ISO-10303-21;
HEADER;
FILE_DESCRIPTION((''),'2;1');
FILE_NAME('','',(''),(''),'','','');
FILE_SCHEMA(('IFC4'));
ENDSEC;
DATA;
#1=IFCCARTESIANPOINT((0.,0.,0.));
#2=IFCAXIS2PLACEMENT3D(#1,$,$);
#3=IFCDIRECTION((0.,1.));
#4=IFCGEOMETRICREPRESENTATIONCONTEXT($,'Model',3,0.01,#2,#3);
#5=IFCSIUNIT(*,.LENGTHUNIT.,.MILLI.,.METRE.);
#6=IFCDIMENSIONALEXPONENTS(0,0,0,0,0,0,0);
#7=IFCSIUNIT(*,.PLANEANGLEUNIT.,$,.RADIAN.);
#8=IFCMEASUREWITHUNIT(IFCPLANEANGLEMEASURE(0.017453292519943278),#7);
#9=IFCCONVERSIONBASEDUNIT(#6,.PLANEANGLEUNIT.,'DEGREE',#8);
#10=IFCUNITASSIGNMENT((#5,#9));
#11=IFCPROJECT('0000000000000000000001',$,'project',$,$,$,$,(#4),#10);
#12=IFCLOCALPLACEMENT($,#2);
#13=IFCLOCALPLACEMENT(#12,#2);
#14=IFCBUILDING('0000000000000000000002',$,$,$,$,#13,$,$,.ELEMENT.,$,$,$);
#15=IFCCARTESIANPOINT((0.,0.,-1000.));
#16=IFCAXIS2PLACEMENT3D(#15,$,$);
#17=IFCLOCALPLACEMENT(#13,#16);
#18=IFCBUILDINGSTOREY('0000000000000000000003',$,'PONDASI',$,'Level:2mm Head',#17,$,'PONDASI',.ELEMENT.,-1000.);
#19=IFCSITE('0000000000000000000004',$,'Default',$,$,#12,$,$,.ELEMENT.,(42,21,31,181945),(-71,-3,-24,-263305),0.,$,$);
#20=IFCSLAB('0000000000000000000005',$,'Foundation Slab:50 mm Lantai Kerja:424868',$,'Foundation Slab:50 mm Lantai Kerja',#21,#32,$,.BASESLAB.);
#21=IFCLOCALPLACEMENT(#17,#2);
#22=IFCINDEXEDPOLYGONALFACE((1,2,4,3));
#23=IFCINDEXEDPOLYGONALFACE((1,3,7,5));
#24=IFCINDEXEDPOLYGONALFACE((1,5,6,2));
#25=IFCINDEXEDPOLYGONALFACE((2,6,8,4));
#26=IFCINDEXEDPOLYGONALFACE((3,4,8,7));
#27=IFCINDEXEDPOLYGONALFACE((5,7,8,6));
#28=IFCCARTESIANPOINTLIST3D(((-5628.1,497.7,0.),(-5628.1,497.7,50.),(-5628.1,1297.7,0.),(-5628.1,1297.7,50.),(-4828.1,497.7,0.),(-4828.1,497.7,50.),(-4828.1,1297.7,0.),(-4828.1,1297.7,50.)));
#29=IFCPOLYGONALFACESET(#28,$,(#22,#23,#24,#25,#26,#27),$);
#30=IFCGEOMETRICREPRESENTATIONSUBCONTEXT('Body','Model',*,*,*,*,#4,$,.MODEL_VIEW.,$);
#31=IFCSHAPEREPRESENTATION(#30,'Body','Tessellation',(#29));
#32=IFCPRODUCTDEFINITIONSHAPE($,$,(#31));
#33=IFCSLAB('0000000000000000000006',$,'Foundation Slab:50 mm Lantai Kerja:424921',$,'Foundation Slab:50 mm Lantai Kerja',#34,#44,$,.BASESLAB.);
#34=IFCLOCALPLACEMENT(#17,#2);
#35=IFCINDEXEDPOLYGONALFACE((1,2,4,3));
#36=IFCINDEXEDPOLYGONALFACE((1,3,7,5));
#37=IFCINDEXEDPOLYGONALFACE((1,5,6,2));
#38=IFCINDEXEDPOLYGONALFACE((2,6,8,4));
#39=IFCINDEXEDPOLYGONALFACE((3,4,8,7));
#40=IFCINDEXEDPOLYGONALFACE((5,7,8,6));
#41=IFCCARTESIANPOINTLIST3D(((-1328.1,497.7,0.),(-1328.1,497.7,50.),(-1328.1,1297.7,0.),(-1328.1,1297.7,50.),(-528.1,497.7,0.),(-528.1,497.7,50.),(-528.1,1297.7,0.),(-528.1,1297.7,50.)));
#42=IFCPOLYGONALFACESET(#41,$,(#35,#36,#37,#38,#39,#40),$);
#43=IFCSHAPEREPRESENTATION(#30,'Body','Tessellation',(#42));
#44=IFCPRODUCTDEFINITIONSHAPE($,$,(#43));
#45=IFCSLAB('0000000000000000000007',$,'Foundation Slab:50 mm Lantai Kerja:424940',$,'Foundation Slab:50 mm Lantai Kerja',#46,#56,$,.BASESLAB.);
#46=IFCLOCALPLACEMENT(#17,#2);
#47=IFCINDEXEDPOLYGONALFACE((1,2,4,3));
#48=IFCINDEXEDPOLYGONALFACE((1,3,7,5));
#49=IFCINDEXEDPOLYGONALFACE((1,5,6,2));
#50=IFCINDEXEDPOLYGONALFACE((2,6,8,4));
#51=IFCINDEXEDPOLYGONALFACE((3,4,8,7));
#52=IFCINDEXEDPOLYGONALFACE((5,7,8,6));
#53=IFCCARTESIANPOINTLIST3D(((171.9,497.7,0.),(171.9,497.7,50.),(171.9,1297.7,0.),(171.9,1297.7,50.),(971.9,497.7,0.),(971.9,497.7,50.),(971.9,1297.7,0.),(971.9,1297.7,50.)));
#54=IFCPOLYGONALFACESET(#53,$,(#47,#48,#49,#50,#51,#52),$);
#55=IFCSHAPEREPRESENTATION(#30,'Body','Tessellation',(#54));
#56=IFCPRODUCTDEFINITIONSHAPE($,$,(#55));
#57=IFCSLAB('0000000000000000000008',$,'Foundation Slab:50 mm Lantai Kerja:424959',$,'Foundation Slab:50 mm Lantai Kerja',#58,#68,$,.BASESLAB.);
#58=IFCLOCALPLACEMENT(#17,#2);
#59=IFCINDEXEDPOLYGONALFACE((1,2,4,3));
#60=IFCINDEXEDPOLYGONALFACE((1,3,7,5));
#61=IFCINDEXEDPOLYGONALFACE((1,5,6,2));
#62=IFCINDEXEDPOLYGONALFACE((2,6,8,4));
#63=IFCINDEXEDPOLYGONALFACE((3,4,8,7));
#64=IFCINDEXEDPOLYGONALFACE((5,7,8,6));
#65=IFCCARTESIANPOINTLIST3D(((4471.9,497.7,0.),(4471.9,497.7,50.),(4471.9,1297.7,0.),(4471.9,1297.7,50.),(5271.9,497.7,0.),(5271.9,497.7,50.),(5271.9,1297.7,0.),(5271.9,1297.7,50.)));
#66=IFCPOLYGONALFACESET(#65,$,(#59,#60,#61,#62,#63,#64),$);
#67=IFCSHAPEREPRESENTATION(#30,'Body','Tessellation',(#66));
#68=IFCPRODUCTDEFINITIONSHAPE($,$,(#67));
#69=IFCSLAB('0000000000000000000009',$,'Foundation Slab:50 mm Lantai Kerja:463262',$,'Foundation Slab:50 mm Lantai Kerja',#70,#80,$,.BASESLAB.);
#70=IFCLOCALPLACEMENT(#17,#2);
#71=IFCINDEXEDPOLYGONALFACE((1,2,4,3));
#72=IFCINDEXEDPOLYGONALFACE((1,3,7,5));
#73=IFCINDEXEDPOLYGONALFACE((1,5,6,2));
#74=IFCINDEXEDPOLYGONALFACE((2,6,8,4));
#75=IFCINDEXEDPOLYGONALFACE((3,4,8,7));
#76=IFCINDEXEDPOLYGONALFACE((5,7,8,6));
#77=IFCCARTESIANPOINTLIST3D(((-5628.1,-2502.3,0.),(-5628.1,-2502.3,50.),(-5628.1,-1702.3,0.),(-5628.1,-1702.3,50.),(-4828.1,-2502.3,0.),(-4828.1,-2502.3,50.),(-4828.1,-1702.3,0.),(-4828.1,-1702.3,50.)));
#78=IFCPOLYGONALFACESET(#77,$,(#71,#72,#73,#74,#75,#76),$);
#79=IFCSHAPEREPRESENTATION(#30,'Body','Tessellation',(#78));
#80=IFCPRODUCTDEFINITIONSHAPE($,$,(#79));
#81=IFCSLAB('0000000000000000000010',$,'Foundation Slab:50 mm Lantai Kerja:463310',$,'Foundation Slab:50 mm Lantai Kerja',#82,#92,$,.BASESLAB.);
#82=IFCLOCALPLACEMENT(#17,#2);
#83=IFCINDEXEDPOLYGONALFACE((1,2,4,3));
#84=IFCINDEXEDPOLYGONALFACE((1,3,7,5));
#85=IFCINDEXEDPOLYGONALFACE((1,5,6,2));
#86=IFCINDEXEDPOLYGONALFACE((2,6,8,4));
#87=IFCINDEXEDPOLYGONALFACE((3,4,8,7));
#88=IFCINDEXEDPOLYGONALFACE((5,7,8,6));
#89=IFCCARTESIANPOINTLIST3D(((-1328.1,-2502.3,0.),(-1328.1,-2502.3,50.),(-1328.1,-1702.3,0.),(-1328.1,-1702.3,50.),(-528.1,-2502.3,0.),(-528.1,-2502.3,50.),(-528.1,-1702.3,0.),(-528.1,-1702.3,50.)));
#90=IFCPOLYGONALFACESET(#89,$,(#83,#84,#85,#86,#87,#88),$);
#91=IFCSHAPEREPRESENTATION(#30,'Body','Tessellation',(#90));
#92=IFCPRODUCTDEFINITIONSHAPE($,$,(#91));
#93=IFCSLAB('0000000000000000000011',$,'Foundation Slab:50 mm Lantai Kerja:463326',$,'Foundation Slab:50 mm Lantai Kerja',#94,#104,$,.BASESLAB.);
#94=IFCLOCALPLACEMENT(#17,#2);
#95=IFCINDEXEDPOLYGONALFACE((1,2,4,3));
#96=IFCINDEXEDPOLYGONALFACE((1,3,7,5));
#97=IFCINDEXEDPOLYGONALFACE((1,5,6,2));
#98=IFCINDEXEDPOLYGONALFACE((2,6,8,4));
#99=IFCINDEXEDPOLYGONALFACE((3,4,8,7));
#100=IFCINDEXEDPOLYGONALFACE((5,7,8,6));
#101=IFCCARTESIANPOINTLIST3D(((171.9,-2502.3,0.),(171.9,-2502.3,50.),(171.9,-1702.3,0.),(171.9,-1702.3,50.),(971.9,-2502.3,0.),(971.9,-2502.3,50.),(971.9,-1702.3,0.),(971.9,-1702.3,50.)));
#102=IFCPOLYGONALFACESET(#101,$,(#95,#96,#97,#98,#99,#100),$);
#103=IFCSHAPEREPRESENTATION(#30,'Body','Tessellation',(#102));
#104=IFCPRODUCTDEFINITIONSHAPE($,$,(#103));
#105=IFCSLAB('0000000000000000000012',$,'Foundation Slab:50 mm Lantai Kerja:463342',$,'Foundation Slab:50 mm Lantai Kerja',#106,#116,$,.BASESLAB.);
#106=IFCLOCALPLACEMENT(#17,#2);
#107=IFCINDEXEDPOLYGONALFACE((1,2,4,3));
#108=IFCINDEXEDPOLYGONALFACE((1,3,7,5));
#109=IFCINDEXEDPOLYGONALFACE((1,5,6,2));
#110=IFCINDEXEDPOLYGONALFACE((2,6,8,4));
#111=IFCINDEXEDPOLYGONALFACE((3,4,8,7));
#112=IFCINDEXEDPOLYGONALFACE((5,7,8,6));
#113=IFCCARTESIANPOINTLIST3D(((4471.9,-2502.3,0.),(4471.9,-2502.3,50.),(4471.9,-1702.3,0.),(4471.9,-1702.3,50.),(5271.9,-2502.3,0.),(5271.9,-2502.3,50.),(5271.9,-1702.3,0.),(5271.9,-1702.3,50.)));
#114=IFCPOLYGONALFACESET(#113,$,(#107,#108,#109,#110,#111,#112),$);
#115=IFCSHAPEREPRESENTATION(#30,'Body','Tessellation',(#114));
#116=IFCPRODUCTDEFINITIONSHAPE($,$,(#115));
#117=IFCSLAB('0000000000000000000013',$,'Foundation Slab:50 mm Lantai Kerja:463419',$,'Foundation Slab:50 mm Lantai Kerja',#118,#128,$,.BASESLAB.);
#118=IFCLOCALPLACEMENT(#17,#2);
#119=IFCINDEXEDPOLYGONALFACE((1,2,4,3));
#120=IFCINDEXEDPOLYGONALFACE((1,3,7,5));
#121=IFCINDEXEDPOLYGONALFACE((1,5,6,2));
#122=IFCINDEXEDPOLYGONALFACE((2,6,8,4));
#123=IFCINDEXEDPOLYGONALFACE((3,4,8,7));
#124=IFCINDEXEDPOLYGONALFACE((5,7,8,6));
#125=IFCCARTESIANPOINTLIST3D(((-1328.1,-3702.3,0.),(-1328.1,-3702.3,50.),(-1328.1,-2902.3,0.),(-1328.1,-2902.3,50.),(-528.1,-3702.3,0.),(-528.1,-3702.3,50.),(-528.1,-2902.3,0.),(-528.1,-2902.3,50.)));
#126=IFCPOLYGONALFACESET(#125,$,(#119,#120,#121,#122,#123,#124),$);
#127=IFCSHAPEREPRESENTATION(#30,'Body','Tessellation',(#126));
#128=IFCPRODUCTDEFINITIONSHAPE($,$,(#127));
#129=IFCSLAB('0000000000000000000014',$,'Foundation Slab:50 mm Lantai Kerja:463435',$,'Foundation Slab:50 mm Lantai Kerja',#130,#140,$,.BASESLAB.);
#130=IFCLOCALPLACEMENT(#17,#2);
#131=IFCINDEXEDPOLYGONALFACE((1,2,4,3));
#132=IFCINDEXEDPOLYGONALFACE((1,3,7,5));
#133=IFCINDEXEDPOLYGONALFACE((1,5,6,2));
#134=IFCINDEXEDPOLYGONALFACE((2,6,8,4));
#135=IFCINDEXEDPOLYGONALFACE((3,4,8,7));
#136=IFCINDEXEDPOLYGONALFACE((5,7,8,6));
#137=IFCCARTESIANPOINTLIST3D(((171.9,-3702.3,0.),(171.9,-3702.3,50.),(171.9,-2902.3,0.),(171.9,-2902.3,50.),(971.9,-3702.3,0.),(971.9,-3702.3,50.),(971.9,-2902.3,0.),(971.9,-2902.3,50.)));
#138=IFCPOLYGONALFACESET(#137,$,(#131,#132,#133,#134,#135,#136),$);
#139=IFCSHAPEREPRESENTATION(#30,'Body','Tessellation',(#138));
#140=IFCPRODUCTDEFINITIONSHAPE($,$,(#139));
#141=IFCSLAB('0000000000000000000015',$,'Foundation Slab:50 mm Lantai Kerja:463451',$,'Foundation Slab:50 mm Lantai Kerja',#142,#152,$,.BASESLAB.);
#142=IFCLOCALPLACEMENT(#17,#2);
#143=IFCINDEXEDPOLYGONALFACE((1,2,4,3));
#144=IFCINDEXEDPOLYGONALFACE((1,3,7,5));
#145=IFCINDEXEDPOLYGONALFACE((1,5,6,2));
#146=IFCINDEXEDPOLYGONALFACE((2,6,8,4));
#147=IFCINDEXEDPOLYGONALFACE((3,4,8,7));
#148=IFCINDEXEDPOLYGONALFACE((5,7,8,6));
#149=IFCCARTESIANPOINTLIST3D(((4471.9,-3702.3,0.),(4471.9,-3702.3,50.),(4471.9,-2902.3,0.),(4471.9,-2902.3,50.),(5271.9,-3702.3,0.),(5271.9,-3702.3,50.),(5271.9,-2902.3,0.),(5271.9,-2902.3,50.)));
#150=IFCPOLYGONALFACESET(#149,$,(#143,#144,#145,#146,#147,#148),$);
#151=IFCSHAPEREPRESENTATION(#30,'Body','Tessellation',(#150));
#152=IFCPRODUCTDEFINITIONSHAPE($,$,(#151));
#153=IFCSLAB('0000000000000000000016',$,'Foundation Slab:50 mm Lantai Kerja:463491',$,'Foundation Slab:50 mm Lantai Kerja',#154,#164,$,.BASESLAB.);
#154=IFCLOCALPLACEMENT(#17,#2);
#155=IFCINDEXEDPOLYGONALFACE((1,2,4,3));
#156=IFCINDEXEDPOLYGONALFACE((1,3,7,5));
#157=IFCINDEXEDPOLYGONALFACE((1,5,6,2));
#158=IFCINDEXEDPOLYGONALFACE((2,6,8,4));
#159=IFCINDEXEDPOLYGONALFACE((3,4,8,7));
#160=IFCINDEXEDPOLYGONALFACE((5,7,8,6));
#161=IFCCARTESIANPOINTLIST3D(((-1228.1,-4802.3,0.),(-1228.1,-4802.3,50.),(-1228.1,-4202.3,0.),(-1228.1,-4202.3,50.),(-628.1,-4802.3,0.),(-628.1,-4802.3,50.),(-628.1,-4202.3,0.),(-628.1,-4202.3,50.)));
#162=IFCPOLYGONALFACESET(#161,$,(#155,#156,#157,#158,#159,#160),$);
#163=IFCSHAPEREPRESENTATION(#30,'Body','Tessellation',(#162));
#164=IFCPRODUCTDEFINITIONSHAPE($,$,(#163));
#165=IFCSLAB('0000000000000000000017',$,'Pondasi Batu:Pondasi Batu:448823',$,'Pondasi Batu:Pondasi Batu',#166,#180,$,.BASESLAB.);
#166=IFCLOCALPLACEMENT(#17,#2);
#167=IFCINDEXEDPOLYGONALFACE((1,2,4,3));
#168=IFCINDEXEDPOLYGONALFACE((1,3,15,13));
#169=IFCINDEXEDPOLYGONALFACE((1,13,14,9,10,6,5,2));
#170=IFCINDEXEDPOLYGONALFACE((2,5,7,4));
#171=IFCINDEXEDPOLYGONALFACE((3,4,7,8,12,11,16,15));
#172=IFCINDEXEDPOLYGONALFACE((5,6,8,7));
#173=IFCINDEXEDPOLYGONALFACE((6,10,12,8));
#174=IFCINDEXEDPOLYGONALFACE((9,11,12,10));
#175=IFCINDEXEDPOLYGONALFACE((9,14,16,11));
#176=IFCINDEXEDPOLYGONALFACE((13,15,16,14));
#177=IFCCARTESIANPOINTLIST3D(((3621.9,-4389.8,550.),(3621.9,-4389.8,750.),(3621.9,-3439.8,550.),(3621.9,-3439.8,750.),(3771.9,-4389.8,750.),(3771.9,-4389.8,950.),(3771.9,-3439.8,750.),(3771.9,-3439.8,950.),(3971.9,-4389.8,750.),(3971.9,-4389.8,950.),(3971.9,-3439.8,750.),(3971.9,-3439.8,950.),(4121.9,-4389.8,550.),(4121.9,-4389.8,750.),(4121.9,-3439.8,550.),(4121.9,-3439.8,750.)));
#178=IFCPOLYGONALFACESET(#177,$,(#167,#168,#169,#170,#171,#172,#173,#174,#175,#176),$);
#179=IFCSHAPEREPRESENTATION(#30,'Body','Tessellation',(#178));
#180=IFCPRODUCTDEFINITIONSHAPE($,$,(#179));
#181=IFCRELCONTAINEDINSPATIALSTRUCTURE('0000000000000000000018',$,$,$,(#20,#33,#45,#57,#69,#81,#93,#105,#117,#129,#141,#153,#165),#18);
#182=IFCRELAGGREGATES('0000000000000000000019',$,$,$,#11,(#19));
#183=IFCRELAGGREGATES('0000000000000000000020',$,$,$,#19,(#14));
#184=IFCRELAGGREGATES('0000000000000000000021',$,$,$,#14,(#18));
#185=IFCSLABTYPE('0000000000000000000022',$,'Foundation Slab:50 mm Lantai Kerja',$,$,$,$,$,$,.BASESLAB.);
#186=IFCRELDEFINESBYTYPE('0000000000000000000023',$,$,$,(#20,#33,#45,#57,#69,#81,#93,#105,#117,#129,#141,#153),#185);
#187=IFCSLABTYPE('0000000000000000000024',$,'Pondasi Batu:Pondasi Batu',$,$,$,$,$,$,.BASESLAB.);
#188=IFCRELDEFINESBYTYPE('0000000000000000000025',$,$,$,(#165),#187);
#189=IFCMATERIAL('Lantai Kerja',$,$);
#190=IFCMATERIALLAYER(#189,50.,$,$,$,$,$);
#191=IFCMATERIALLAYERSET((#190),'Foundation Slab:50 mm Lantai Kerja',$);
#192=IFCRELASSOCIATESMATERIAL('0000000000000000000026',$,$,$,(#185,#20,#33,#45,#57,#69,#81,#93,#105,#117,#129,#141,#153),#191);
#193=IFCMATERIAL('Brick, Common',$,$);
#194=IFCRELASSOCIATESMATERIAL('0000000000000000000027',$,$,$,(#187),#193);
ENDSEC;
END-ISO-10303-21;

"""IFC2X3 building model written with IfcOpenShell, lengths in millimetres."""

from ifc_helpers import new_model, entity, si_unit, converted_unit, direction, frame, origin, origin_2d_with_axis, place, context, subcontext, project, spatial, polyline, rectangle, outline, extrude, material, layer, layer_set, layer_usage, type_object, element, save


model = new_model("IFC2X3")

# Units and contexts
model_context = context("Model", 3, precision=0.01, world=origin(), true_north=direction((0.0, 1.0)))
body_context = subcontext(model_context, "Body", "Model", "MODEL_VIEW")
ifc_project = project(units=[si_unit("LENGTHUNIT", "METRE", prefix="MILLI"), converted_unit("PLANEANGLEUNIT", "DEGREE", entity("IfcPlaneAngleMeasure", 0.017453292519943278), si_unit("PLANEANGLEUNIT", "RADIAN"), dimensions=[0, 0, 0, 0, 0, 0, 0])], contexts=[model_context])

# Site, building, storey
site_placement = place(None, origin())
site = spatial("IfcSite", under=ifc_project, at=site_placement, Name="Default", CompositionType="ELEMENT", RefLatitude=(42, 21, 31, 181945), RefLongitude=(-71, -3, -24, -263305), RefElevation=0.0)
building_placement = place(site_placement, origin())
building = spatial("IfcBuilding", under=site, at=building_placement, CompositionType="ELEMENT")
storey_placement = place(building_placement, frame((0.0, 0.0, -1000.0)))
storey = spatial("IfcBuildingStorey", under=building, at=storey_placement, Name="PONDASI", ObjectType="Level:2mm Head", LongName="PONDASI", CompositionType="ELEMENT", Elevation=-1000.0)

# Slabs
ifc_material_1 = material(Name="Lantai Kerja")
ifc_layer_1 = layer(ifc_material_1, 50.0)
ifc_layer_set_1 = layer_set([ifc_layer_1], Name="Foundation Slab:50 mm Lantai Kerja")
slab_type_1 = type_object("IfcSlabType", Name="Foundation Slab:50 mm Lantai Kerja", PredefinedType="BASESLAB", material=ifc_layer_set_1)
ifc_layer_usage_1 = layer_usage(ifc_layer_set_1, "AXIS3", "POSITIVE", 0.0)
slab_1_placement = place(storey_placement, origin())
element("IfcSlab", 1, at=slab_1_placement, inside=storey, type_object=slab_type_1, material=ifc_layer_usage_1, Name="Foundation Slab:50 mm Lantai Kerja:424868", ObjectType="Foundation Slab:50 mm Lantai Kerja", PredefinedType="BASESLAB", context=body_context, shape_type="SweptSolid", body=[
    extrude(rectangle(XDim=800.0, YDim=800.0, at=origin_2d_with_axis()), frame((-5228.1, 897.7, 50.0), z_axis=(0.0, 0.0, -1.0), x_axis=(0.0, 1.0, 0.0)), (0.0, 0.0, 1.0), 50.0),
])
ifc_layer_usage_2 = layer_usage(ifc_layer_set_1, "AXIS3", "POSITIVE", 0.0)
slab_2_placement = place(storey_placement, origin())
element("IfcSlab", 2, at=slab_2_placement, inside=storey, type_object=slab_type_1, material=ifc_layer_usage_2, Name="Foundation Slab:50 mm Lantai Kerja:424921", ObjectType="Foundation Slab:50 mm Lantai Kerja", PredefinedType="BASESLAB", context=body_context, shape_type="SweptSolid", body=[
    extrude(rectangle(XDim=800.0, YDim=800.0, at=origin_2d_with_axis()), frame((-928.1, 897.7, 50.0), z_axis=(0.0, 0.0, -1.0), x_axis=(0.0, 1.0, 0.0)), (0.0, 0.0, 1.0), 50.0),
])
ifc_layer_usage_3 = layer_usage(ifc_layer_set_1, "AXIS3", "POSITIVE", 0.0)
slab_3_placement = place(storey_placement, origin())
element("IfcSlab", 3, at=slab_3_placement, inside=storey, type_object=slab_type_1, material=ifc_layer_usage_3, Name="Foundation Slab:50 mm Lantai Kerja:424940", ObjectType="Foundation Slab:50 mm Lantai Kerja", PredefinedType="BASESLAB", context=body_context, shape_type="SweptSolid", body=[
    extrude(rectangle(XDim=800.0, YDim=800.0, at=origin_2d_with_axis()), frame((571.9, 897.7, 50.0), z_axis=(0.0, 0.0, -1.0), x_axis=(0.0, 1.0, 0.0)), (0.0, 0.0, 1.0), 50.0),
])
ifc_layer_usage_4 = layer_usage(ifc_layer_set_1, "AXIS3", "POSITIVE", 0.0)
slab_4_placement = place(storey_placement, origin())
element("IfcSlab", 4, at=slab_4_placement, inside=storey, type_object=slab_type_1, material=ifc_layer_usage_4, Name="Foundation Slab:50 mm Lantai Kerja:424959", ObjectType="Foundation Slab:50 mm Lantai Kerja", PredefinedType="BASESLAB", context=body_context, shape_type="SweptSolid", body=[
    extrude(rectangle(XDim=800.0, YDim=800.0, at=origin_2d_with_axis()), frame((4871.9, 897.7, 50.0), z_axis=(0.0, 0.0, -1.0), x_axis=(0.0, 1.0, 0.0)), (0.0, 0.0, 1.0), 50.0),
])
ifc_layer_usage_5 = layer_usage(ifc_layer_set_1, "AXIS3", "POSITIVE", 0.0)
slab_5_placement = place(storey_placement, origin())
element("IfcSlab", 5, at=slab_5_placement, inside=storey, type_object=slab_type_1, material=ifc_layer_usage_5, Name="Foundation Slab:50 mm Lantai Kerja:463262", ObjectType="Foundation Slab:50 mm Lantai Kerja", PredefinedType="BASESLAB", context=body_context, shape_type="SweptSolid", body=[
    extrude(rectangle(XDim=800.0, YDim=800.0, at=origin_2d_with_axis()), frame((-5228.1, -2102.3, 50.0), z_axis=(0.0, 0.0, -1.0), x_axis=(0.0, 1.0, 0.0)), (0.0, 0.0, 1.0), 50.0),
])
ifc_layer_usage_6 = layer_usage(ifc_layer_set_1, "AXIS3", "POSITIVE", 0.0)
slab_6_placement = place(storey_placement, origin())
element("IfcSlab", 6, at=slab_6_placement, inside=storey, type_object=slab_type_1, material=ifc_layer_usage_6, Name="Foundation Slab:50 mm Lantai Kerja:463310", ObjectType="Foundation Slab:50 mm Lantai Kerja", PredefinedType="BASESLAB", context=body_context, shape_type="SweptSolid", body=[
    extrude(rectangle(XDim=800.0, YDim=800.0, at=origin_2d_with_axis()), frame((-928.1, -2102.3, 50.0), z_axis=(0.0, 0.0, -1.0), x_axis=(0.0, 1.0, 0.0)), (0.0, 0.0, 1.0), 50.0),
])
ifc_layer_usage_7 = layer_usage(ifc_layer_set_1, "AXIS3", "POSITIVE", 0.0)
slab_7_placement = place(storey_placement, origin())
element("IfcSlab", 7, at=slab_7_placement, inside=storey, type_object=slab_type_1, material=ifc_layer_usage_7, Name="Foundation Slab:50 mm Lantai Kerja:463326", ObjectType="Foundation Slab:50 mm Lantai Kerja", PredefinedType="BASESLAB", context=body_context, shape_type="SweptSolid", body=[
    extrude(rectangle(XDim=800.0, YDim=800.0, at=origin_2d_with_axis()), frame((571.9, -2102.3, 50.0), z_axis=(0.0, 0.0, -1.0), x_axis=(0.0, 1.0, 0.0)), (0.0, 0.0, 1.0), 50.0),
])
ifc_layer_usage_8 = layer_usage(ifc_layer_set_1, "AXIS3", "POSITIVE", 0.0)
slab_8_placement = place(storey_placement, origin())
element("IfcSlab", 8, at=slab_8_placement, inside=storey, type_object=slab_type_1, material=ifc_layer_usage_8, Name="Foundation Slab:50 mm Lantai Kerja:463342", ObjectType="Foundation Slab:50 mm Lantai Kerja", PredefinedType="BASESLAB", context=body_context, shape_type="SweptSolid", body=[
    extrude(rectangle(XDim=800.0, YDim=800.0, at=origin_2d_with_axis()), frame((4871.9, -2102.3, 50.0), z_axis=(0.0, 0.0, -1.0), x_axis=(0.0, 1.0, 0.0)), (0.0, 0.0, 1.0), 50.0),
])
ifc_layer_usage_9 = layer_usage(ifc_layer_set_1, "AXIS3", "POSITIVE", 0.0)
slab_9_placement = place(storey_placement, origin())
element("IfcSlab", 9, at=slab_9_placement, inside=storey, type_object=slab_type_1, material=ifc_layer_usage_9, Name="Foundation Slab:50 mm Lantai Kerja:463419", ObjectType="Foundation Slab:50 mm Lantai Kerja", PredefinedType="BASESLAB", context=body_context, shape_type="SweptSolid", body=[
    extrude(rectangle(XDim=800.0, YDim=800.0, at=origin_2d_with_axis()), frame((-928.1, -3302.3, 50.0), z_axis=(0.0, 0.0, -1.0), x_axis=(0.0, 1.0, 0.0)), (0.0, 0.0, 1.0), 50.0),
])
ifc_layer_usage_10 = layer_usage(ifc_layer_set_1, "AXIS3", "POSITIVE", 0.0)
slab_10_placement = place(storey_placement, origin())
element("IfcSlab", 10, at=slab_10_placement, inside=storey, type_object=slab_type_1, material=ifc_layer_usage_10, Name="Foundation Slab:50 mm Lantai Kerja:463435", ObjectType="Foundation Slab:50 mm Lantai Kerja", PredefinedType="BASESLAB", context=body_context, shape_type="SweptSolid", body=[
    extrude(rectangle(XDim=800.0, YDim=800.0, at=origin_2d_with_axis()), frame((571.9, -3302.3, 50.0), z_axis=(0.0, 0.0, -1.0), x_axis=(0.0, 1.0, 0.0)), (0.0, 0.0, 1.0), 50.0),
])
ifc_layer_usage_11 = layer_usage(ifc_layer_set_1, "AXIS3", "POSITIVE", 0.0)
slab_11_placement = place(storey_placement, origin())
element("IfcSlab", 11, at=slab_11_placement, inside=storey, type_object=slab_type_1, material=ifc_layer_usage_11, Name="Foundation Slab:50 mm Lantai Kerja:463451", ObjectType="Foundation Slab:50 mm Lantai Kerja", PredefinedType="BASESLAB", context=body_context, shape_type="SweptSolid", body=[
    extrude(rectangle(XDim=800.0, YDim=800.0, at=origin_2d_with_axis()), frame((4871.9, -3302.3, 50.0), z_axis=(0.0, 0.0, -1.0), x_axis=(0.0, 1.0, 0.0)), (0.0, 0.0, 1.0), 50.0),
])
ifc_layer_usage_12 = layer_usage(ifc_layer_set_1, "AXIS3", "POSITIVE", 0.0)
slab_12_placement = place(storey_placement, origin())
element("IfcSlab", 12, at=slab_12_placement, inside=storey, type_object=slab_type_1, material=ifc_layer_usage_12, Name="Foundation Slab:50 mm Lantai Kerja:463491", ObjectType="Foundation Slab:50 mm Lantai Kerja", PredefinedType="BASESLAB", context=body_context, shape_type="SweptSolid", body=[
    extrude(rectangle(XDim=600.0, YDim=600.0, at=origin_2d_with_axis()), frame((-928.1, -4502.3, 50.0), z_axis=(0.0, 0.0, -1.0), x_axis=(0.0, 1.0, 0.0)), (0.0, 0.0, 1.0), 50.0),
])
ifc_material_2 = material(Name="Brick, Common")
slab_type_2 = type_object("IfcSlabType", Name="Pondasi Batu:Pondasi Batu", PredefinedType="BASESLAB", material=ifc_material_2)
slab_13_placement = place(storey_placement, origin())
element("IfcSlab", 13, at=slab_13_placement, inside=storey, type_object=slab_type_2, Name="Pondasi Batu:Pondasi Batu:448823", ObjectType="Pondasi Batu:Pondasi Batu", PredefinedType="BASESLAB", context=body_context, shape_type="SweptSolid", body=[
    extrude(outline(polyline([(-200.0, 100.0), (-200.0, -100.0), (0.0, -100.0), (0.0, -250.0), (200.0, -250.0), (200.0, 250.0), (0.0, 250.0), (0.0, 100.0), (-200.0, 100.0)])), frame((3871.9, -4389.8, 750.0), z_axis=(0.0, -1.0, 0.0), x_axis=(0.0, 0.0, -1.0)), (0.0, 0.0, -1.0), 950.0),
])

save(model, "model.ifc")
